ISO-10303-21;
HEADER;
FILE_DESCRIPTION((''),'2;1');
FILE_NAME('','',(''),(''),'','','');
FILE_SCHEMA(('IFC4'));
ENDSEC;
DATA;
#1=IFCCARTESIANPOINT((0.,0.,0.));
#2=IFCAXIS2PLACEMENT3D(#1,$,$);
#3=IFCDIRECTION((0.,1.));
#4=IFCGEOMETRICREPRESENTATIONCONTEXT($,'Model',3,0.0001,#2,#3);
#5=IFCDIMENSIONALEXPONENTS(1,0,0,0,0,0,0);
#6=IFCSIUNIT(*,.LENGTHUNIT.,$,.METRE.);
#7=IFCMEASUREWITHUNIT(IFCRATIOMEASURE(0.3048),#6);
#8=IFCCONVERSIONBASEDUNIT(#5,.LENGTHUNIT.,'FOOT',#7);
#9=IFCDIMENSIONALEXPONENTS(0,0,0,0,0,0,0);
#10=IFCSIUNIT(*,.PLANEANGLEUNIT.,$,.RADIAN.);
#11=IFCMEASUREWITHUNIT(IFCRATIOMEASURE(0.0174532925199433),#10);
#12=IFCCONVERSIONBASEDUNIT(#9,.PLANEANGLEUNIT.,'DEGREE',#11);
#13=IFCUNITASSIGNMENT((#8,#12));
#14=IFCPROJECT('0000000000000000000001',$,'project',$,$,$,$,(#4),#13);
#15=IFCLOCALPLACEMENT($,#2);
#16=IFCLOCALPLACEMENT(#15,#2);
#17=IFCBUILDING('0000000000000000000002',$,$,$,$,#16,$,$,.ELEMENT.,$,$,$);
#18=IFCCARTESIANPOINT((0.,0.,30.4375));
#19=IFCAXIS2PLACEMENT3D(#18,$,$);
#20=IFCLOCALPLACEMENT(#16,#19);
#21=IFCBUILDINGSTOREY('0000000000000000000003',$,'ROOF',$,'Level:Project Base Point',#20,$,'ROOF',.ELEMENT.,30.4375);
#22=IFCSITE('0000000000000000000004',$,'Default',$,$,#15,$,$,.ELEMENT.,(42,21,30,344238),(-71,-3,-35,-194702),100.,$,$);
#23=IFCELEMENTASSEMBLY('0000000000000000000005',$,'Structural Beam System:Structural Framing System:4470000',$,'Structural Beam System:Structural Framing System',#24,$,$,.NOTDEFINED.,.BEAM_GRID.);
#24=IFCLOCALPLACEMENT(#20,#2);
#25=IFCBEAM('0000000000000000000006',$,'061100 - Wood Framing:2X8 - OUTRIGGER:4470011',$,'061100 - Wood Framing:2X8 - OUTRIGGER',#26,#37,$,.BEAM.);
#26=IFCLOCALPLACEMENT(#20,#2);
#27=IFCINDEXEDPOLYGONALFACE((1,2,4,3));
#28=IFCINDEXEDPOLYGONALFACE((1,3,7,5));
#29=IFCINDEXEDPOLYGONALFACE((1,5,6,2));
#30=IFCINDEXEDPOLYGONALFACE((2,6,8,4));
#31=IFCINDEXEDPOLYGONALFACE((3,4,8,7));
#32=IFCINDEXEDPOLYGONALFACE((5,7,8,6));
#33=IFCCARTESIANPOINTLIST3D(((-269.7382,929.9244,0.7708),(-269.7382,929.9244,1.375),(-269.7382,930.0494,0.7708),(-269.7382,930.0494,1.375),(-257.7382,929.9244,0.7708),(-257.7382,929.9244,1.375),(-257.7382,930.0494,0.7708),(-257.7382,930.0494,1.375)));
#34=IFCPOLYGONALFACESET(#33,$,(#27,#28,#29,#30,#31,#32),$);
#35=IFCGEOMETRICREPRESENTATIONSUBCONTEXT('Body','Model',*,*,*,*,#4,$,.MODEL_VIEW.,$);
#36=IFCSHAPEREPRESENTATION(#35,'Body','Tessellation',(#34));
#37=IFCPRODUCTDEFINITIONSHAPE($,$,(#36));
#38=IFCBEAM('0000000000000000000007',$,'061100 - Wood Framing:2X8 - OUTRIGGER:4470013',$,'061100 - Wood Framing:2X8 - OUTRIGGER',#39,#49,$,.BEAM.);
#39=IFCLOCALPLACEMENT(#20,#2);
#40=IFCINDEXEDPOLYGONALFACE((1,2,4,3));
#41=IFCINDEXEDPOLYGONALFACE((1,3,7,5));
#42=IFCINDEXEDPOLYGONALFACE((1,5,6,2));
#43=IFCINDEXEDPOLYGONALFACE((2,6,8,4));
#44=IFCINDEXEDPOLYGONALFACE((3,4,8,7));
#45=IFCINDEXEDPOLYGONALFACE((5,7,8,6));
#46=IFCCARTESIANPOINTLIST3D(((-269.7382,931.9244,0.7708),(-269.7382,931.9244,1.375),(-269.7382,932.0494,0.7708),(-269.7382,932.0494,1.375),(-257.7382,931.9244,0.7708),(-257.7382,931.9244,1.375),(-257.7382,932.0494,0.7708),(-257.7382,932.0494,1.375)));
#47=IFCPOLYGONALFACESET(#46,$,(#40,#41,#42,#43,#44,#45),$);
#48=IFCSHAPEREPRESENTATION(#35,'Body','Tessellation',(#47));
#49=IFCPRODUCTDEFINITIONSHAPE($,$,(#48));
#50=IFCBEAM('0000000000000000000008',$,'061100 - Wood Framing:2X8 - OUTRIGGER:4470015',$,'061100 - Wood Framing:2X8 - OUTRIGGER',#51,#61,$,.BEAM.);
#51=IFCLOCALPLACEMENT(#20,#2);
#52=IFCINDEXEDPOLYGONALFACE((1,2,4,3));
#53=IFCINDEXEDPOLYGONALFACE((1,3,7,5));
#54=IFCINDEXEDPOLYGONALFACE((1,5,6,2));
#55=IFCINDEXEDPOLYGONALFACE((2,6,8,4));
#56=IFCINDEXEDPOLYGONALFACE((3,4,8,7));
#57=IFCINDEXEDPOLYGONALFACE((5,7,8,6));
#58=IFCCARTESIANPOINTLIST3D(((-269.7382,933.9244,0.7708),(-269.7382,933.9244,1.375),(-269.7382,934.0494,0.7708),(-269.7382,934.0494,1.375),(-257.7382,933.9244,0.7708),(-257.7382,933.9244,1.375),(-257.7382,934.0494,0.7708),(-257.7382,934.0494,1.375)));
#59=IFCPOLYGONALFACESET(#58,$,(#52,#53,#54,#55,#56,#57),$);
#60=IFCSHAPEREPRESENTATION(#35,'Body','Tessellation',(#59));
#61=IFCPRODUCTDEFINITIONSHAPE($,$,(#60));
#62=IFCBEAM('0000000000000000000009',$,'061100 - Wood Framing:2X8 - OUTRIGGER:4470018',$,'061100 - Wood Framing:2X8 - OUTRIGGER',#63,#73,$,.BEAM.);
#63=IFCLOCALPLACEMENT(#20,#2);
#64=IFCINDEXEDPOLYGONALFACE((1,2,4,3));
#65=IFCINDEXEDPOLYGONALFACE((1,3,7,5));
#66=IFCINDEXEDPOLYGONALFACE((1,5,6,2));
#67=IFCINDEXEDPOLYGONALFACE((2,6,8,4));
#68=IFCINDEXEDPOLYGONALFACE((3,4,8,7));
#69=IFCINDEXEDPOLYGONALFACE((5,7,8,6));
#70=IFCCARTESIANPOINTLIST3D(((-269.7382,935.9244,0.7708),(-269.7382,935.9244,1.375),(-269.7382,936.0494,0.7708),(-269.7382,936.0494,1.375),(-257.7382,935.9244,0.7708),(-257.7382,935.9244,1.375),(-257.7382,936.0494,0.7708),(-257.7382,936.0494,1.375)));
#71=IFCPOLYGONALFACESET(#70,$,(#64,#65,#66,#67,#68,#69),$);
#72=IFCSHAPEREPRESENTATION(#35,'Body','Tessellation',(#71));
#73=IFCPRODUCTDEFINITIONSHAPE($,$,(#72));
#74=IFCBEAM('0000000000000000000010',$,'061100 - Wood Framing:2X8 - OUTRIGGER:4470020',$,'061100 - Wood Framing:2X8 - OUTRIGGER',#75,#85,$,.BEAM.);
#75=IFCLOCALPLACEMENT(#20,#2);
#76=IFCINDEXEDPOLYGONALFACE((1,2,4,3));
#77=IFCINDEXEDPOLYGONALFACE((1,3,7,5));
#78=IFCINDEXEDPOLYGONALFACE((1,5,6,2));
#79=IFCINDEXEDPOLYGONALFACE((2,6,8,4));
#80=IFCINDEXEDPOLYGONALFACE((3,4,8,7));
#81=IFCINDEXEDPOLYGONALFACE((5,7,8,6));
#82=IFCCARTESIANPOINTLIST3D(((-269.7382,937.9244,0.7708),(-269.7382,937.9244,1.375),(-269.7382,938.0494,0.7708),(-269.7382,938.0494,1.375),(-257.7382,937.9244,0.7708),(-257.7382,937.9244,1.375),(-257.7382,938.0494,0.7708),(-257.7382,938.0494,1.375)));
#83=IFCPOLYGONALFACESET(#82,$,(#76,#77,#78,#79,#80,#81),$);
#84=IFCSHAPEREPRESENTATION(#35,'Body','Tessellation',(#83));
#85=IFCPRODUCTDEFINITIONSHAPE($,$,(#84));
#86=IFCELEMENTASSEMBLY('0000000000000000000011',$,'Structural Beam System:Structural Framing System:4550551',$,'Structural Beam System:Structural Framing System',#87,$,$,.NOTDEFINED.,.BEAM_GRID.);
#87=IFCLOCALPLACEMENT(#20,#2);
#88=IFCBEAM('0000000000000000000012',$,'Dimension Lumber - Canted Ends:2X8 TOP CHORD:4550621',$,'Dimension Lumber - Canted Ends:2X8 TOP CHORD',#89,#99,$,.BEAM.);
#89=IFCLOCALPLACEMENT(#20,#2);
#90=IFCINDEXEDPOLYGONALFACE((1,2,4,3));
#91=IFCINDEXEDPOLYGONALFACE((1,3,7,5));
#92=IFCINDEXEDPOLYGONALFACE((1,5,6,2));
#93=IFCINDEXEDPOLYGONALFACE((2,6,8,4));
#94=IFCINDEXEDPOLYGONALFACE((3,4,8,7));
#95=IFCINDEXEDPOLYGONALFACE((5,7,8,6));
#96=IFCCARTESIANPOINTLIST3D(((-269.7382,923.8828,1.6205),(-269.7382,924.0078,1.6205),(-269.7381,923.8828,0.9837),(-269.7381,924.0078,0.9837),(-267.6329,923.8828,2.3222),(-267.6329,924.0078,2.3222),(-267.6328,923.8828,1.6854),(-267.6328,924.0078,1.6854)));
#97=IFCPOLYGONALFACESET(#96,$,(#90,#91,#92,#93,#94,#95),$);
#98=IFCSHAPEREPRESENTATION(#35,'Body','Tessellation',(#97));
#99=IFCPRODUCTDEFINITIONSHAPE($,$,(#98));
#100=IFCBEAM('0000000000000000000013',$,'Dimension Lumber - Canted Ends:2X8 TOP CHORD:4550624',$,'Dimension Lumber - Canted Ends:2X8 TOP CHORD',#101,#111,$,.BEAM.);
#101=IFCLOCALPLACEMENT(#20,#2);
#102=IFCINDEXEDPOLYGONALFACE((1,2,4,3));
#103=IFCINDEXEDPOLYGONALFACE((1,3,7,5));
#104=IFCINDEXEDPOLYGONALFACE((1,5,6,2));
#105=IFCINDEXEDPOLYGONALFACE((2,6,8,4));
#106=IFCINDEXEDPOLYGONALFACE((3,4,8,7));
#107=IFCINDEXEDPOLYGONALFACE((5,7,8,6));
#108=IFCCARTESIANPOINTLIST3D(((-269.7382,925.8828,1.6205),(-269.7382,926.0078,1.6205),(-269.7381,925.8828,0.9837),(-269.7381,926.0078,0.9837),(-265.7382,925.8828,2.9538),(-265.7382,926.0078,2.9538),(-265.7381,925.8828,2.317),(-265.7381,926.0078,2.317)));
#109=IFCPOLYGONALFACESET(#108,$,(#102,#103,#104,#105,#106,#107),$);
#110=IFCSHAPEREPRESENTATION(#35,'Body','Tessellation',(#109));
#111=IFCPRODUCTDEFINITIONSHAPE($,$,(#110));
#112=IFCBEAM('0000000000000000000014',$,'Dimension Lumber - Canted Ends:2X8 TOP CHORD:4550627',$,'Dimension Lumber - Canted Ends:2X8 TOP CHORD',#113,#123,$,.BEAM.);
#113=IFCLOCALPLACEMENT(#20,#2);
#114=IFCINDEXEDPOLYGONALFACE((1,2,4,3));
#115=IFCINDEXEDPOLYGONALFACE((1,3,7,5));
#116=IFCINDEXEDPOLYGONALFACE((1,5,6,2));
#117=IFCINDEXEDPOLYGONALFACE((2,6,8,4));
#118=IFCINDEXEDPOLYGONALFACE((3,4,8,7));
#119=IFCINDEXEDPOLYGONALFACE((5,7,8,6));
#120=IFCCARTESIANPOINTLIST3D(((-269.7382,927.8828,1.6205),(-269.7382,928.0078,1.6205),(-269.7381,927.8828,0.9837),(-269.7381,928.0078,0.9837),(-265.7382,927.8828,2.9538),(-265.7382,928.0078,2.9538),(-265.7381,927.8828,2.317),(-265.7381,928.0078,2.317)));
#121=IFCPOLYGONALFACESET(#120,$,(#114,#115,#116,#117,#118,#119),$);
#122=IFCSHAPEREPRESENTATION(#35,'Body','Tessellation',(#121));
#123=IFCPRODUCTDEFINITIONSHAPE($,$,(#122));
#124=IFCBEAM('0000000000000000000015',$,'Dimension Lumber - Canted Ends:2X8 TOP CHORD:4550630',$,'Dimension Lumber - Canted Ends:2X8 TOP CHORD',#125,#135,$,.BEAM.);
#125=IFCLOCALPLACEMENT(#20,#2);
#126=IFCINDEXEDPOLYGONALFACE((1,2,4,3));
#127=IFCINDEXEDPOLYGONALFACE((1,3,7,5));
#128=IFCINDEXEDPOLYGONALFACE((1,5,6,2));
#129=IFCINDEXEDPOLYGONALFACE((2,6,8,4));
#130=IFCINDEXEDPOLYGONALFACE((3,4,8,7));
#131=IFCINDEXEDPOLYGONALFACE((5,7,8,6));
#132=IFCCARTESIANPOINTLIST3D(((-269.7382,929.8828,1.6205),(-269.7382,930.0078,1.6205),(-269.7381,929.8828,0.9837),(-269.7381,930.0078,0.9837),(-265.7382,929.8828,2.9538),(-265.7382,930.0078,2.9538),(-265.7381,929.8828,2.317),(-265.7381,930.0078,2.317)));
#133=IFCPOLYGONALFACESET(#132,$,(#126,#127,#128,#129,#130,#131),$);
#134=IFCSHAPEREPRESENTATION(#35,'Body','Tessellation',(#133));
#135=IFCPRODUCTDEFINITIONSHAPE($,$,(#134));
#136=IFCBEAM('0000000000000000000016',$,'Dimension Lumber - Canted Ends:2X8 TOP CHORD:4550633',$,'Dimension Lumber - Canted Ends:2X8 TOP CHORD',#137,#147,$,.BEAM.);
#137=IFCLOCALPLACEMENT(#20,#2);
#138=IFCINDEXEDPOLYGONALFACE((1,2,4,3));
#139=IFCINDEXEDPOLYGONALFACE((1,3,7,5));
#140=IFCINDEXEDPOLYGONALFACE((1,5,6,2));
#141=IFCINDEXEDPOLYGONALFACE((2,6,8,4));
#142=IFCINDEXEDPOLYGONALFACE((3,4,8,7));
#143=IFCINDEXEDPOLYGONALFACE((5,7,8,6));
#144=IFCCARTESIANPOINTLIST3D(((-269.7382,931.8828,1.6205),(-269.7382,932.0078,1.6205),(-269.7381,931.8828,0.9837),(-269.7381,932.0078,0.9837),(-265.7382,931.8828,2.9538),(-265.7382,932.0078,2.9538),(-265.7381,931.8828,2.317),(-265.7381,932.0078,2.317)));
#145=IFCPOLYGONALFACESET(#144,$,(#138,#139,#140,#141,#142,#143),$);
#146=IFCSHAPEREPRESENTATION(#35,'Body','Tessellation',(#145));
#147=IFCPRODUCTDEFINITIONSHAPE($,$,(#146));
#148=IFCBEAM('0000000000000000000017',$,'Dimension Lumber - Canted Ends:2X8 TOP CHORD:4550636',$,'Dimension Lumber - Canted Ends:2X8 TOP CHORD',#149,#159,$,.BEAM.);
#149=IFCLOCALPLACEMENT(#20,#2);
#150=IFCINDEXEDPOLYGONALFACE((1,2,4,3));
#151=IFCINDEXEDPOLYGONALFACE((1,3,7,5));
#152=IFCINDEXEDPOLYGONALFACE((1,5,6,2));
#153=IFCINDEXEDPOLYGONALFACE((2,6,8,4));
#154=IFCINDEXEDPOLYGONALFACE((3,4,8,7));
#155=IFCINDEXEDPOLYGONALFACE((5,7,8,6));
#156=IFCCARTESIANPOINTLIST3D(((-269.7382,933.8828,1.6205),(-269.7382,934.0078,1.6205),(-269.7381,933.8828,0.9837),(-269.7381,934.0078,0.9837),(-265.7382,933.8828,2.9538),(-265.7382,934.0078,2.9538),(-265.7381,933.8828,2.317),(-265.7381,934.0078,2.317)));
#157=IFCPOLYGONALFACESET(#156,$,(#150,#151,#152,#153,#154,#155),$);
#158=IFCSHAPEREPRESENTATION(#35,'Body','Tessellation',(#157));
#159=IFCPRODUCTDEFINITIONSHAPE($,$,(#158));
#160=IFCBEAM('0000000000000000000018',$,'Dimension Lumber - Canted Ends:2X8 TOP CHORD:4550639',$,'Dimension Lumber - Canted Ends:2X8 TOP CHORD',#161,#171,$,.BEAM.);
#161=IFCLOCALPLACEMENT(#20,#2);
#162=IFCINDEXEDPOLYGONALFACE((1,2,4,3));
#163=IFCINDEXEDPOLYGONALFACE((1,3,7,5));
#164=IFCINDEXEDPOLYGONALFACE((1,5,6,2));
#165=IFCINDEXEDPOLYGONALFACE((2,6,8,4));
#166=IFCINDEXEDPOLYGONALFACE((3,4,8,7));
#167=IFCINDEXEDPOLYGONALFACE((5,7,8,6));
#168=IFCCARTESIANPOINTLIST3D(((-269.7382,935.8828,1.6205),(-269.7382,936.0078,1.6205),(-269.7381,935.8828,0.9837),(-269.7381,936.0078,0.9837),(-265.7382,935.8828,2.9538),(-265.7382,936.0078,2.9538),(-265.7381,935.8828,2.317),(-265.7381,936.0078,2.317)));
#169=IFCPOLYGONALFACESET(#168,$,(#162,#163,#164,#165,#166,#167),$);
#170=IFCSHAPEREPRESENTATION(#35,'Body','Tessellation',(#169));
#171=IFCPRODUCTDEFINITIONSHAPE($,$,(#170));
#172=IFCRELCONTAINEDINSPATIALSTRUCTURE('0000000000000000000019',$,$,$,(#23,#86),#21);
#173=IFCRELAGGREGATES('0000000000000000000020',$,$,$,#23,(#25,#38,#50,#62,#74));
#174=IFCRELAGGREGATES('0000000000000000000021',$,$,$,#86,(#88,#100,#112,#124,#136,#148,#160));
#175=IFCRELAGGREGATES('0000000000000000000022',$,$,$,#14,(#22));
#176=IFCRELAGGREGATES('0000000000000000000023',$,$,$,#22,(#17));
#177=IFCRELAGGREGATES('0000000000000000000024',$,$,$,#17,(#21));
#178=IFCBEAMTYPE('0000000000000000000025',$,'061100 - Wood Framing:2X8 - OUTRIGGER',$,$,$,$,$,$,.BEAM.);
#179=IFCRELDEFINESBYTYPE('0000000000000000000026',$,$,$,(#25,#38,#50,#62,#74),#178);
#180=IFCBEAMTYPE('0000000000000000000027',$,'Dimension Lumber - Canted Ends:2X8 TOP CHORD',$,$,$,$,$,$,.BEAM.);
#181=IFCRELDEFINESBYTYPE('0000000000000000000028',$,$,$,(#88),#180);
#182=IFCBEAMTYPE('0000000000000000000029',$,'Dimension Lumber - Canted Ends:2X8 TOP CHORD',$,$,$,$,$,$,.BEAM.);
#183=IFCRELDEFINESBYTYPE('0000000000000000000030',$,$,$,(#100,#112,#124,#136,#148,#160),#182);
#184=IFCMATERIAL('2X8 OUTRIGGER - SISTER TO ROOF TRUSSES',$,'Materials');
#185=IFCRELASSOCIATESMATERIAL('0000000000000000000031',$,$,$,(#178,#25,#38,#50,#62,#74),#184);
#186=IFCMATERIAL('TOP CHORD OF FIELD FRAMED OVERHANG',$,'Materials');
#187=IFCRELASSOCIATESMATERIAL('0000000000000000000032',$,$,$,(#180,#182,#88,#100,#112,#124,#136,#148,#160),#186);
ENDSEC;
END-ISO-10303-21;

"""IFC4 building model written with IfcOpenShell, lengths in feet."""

from ifc_helpers import new_model, entity, si_unit, converted_unit, direction, frame, frame_2d, origin, origin_2d_with_axis, place, context, subcontext, project, spatial, rectangle, extrude, clip, halfspace, source, transform, mapped, material, material_profile, profile_set, profile_usage, type_object, type_shapes, element, aggregate, save


model = new_model("IFC4")

# Units and contexts
model_context = context("Model", 3, precision=0.0001, world=origin(), true_north=direction((0.0, 1.0)))
body_context = subcontext(model_context, "Body", "Model", "MODEL_VIEW")
ifc_project = project(units=[converted_unit("LENGTHUNIT", "FOOT", entity("IfcRatioMeasure", 0.3048), si_unit("LENGTHUNIT", "METRE"), dimensions=[1, 0, 0, 0, 0, 0, 0]), converted_unit("PLANEANGLEUNIT", "DEGREE", entity("IfcRatioMeasure", 0.0174532925199433), si_unit("PLANEANGLEUNIT", "RADIAN"), dimensions=[0, 0, 0, 0, 0, 0, 0])], contexts=[model_context])

# Site, building, storey
site_placement = place(None, origin())
site = spatial("IfcSite", under=ifc_project, at=site_placement, Name="Default", CompositionType="ELEMENT", RefLatitude=(42, 21, 30, 344238), RefLongitude=(-71, -3, -35, -194702), RefElevation=100.0)
building_placement = place(site_placement, origin())
building = spatial("IfcBuilding", under=site, at=building_placement, CompositionType="ELEMENT")
storey_placement = place(building_placement, frame((0.0, 0.0, 30.4375)))
storey = spatial("IfcBuildingStorey", under=building, at=storey_placement, Name="ROOF", ObjectType="Level:Project Base Point", LongName="ROOF", CompositionType="ELEMENT", Elevation=30.4375)

# Element assemblies, beams
ifc_material_1 = material(Name="TOP CHORD OF FIELD FRAMED OVERHANG", Category="Materials")
ifc_material_profile_1 = material_profile(ifc_material_1, rectangle(XDim=0.6042, YDim=0.125, at=origin_2d_with_axis()), Name="2X8 TOP CHORD")
ifc_profile_set_1 = profile_set([ifc_material_profile_1], Name="2X8 TOP CHORD")
assembly_1_placement = place(storey_placement, origin())
assembly_1 = element("IfcElementAssembly", 1, at=assembly_1_placement, inside=storey, Name="Structural Beam System:Structural Framing System:4470000", ObjectType="Structural Beam System:Structural Framing System", AssemblyPlace="NOTDEFINED", PredefinedType="BEAM_GRID")
ifc_material_2 = material(Name="2X8 OUTRIGGER - SISTER TO ROOF TRUSSES", Category="Materials")
ifc_material_profile_2 = material_profile(ifc_material_2, rectangle(XDim=0.6042, YDim=0.125, at=origin_2d_with_axis()), Name="2X8 - OUTRIGGER")
ifc_profile_set_2 = profile_set([ifc_material_profile_2], Name="2X8 - OUTRIGGER")
beam_type_1 = type_object("IfcBeamType", Name="061100 - Wood Framing:2X8 - OUTRIGGER", PredefinedType="BEAM", material=ifc_profile_set_2)
shared_shape_1 = source(origin(), body_context, "Body", "SweptSolid", [
    extrude(rectangle(XDim=0.6042, YDim=0.125, at=origin_2d_with_axis()), frame((-6.0, 0.0, 0.0), z_axis=(1.0, 0.0, 0.0), x_axis=(0.0, 0.0, -1.0)), (0.0, 0.0, 1.0), 12.0),
])
type_shapes(beam_type_1, [shared_shape_1])
ifc_profile_usage_1 = profile_usage(ifc_profile_set_2, cardinal=8)
beam_1_placement = place(assembly_1_placement, frame((-263.7382, 929.9869, 1.0729), z_axis=(0.0, 0.0, 1.0), x_axis=(-1.0, 0.0, 0.0)))
beam_1 = element("IfcBeam", 2, at=beam_1_placement, type_object=beam_type_1, material=ifc_profile_usage_1, Name="061100 - Wood Framing:2X8 - OUTRIGGER:4470011", ObjectType="061100 - Wood Framing:2X8 - OUTRIGGER", PredefinedType="BEAM", context=body_context, shape_type="MappedRepresentation", body=[
    mapped(shared_shape_1, transform((0.0, 0.0, 0.0), scale=1.0)),
])
ifc_profile_usage_2 = profile_usage(ifc_profile_set_2, cardinal=8)
beam_2_placement = place(assembly_1_placement, frame((-263.7382, 931.9869, 1.0729), z_axis=(0.0, 0.0, 1.0), x_axis=(-1.0, 0.0, 0.0)))
beam_2 = element("IfcBeam", 3, at=beam_2_placement, type_object=beam_type_1, material=ifc_profile_usage_2, Name="061100 - Wood Framing:2X8 - OUTRIGGER:4470013", ObjectType="061100 - Wood Framing:2X8 - OUTRIGGER", PredefinedType="BEAM", context=body_context, shape_type="MappedRepresentation", body=[
    mapped(shared_shape_1, transform((0.0, 0.0, 0.0), scale=1.0)),
])
ifc_profile_usage_3 = profile_usage(ifc_profile_set_2, cardinal=8)
beam_3_placement = place(assembly_1_placement, frame((-263.7382, 933.9869, 1.0729), z_axis=(0.0, 0.0, 1.0), x_axis=(-1.0, 0.0, 0.0)))
beam_3 = element("IfcBeam", 4, at=beam_3_placement, type_object=beam_type_1, material=ifc_profile_usage_3, Name="061100 - Wood Framing:2X8 - OUTRIGGER:4470015", ObjectType="061100 - Wood Framing:2X8 - OUTRIGGER", PredefinedType="BEAM", context=body_context, shape_type="MappedRepresentation", body=[
    mapped(shared_shape_1, transform((0.0, 0.0, 0.0), scale=1.0)),
])
ifc_profile_usage_4 = profile_usage(ifc_profile_set_2, cardinal=8)
beam_4_placement = place(assembly_1_placement, frame((-263.7382, 935.9869, 1.0729), z_axis=(0.0, 0.0, 1.0), x_axis=(-1.0, 0.0, 0.0)))
beam_4 = element("IfcBeam", 5, at=beam_4_placement, type_object=beam_type_1, material=ifc_profile_usage_4, Name="061100 - Wood Framing:2X8 - OUTRIGGER:4470018", ObjectType="061100 - Wood Framing:2X8 - OUTRIGGER", PredefinedType="BEAM", context=body_context, shape_type="MappedRepresentation", body=[
    mapped(shared_shape_1, transform((0.0, 0.0, 0.0), scale=1.0)),
])
ifc_profile_usage_5 = profile_usage(ifc_profile_set_2, cardinal=8)
beam_5_placement = place(assembly_1_placement, frame((-263.7382, 937.9869, 1.0729), z_axis=(0.0, 0.0, 1.0), x_axis=(-1.0, 0.0, 0.0)))
beam_5 = element("IfcBeam", 6, at=beam_5_placement, type_object=beam_type_1, material=ifc_profile_usage_5, Name="061100 - Wood Framing:2X8 - OUTRIGGER:4470020", ObjectType="061100 - Wood Framing:2X8 - OUTRIGGER", PredefinedType="BEAM", context=body_context, shape_type="MappedRepresentation", body=[
    mapped(shared_shape_1, transform((0.0, 0.0, 0.0), scale=1.0)),
])
aggregate(assembly_1, [beam_1, beam_2, beam_3, beam_4, beam_5])
assembly_2_placement = place(storey_placement, origin())
assembly_2 = element("IfcElementAssembly", 7, at=assembly_2_placement, inside=storey, Name="Structural Beam System:Structural Framing System:4550551", ObjectType="Structural Beam System:Structural Framing System", AssemblyPlace="NOTDEFINED", PredefinedType="BEAM_GRID")
ifc_profile_usage_6 = profile_usage(ifc_profile_set_1, cardinal=8)
beam_type_2 = type_object("IfcBeamType", Name="Dimension Lumber - Canted Ends:2X8 TOP CHORD", PredefinedType="BEAM", material=ifc_profile_set_1)
shared_shape_2 = source(origin(), body_context, "Body", "Clipping", [
    clip(clip(extrude(rectangle(XDim=0.6042, YDim=0.125, at=frame_2d((0.0, 0.0), x_axis=(1.0, 0.0))), frame((-1.1096, 0.0, 0.0), z_axis=(1.0, 0.0, 0.0), x_axis=(0.0, 0.0, -1.0)), (0.0, 0.0, 1.0), 2.4205), halfspace(frame((1.1096, -0.0625, -0.3021), z_axis=(0.948711, 0.0, -0.316146), x_axis=(0.0, 1.0, 0.0)), False)), halfspace(frame((-0.9083, -0.0625, 0.3021), z_axis=(-0.948711, 0.0, 0.316146), x_axis=(0.0, 1.0, 0.0)), False)),
])
type_shapes(beam_type_2, [shared_shape_2])
beam_6_placement = place(assembly_2_placement, frame((-268.781, 923.9453, 1.6211), z_axis=(-0.316228, 0.0, 0.948683), x_axis=(0.948683, 0.0, 0.316228)))
beam_6 = element("IfcBeam", 8, at=beam_6_placement, type_object=beam_type_2, material=ifc_profile_usage_6, Name="Dimension Lumber - Canted Ends:2X8 TOP CHORD:4550621", ObjectType="Dimension Lumber - Canted Ends:2X8 TOP CHORD", PredefinedType="BEAM", context=body_context, shape_type="MappedRepresentation", body=[
    mapped(shared_shape_2, transform((0.0, 0.0, 0.0), scale=1.0)),
])
ifc_profile_usage_7 = profile_usage(ifc_profile_set_1, cardinal=8)
beam_type_3 = type_object("IfcBeamType", Name="Dimension Lumber - Canted Ends:2X8 TOP CHORD", PredefinedType="BEAM", material=ifc_profile_set_1)
shared_shape_3 = source(origin(), body_context, "Body", "Clipping", [
    clip(clip(extrude(rectangle(XDim=0.6042, YDim=0.125, at=frame_2d((0.0, 0.0), x_axis=(1.0, 0.0))), frame((-2.1082, 0.0, 0.0), z_axis=(1.0, 0.0, 0.0), x_axis=(0.0, 0.0, -1.0)), (0.0, 0.0, 1.0), 4.4177), halfspace(frame((2.1082, -0.0625, -0.3021), z_axis=(0.948711, 0.0, -0.316146), x_axis=(0.0, 1.0, 0.0)), False)), halfspace(frame((-1.9069, -0.0625, 0.3021), z_axis=(-0.948711, 0.0, 0.316146), x_axis=(0.0, 1.0, 0.0)), False)),
])
type_shapes(beam_type_3, [shared_shape_3])
beam_7_placement = place(assembly_2_placement, frame((-267.8337, 925.9453, 1.9369), z_axis=(-0.316228, 0.0, 0.948683), x_axis=(0.948683, 0.0, 0.316228)))
beam_7 = element("IfcBeam", 9, at=beam_7_placement, type_object=beam_type_3, material=ifc_profile_usage_7, Name="Dimension Lumber - Canted Ends:2X8 TOP CHORD:4550624", ObjectType="Dimension Lumber - Canted Ends:2X8 TOP CHORD", PredefinedType="BEAM", context=body_context, shape_type="MappedRepresentation", body=[
    mapped(shared_shape_3, transform((0.0, 0.0, 0.0), scale=1.0)),
])
ifc_profile_usage_8 = profile_usage(ifc_profile_set_1, cardinal=8)
beam_8_placement = place(assembly_2_placement, frame((-267.8337, 927.9453, 1.9369), z_axis=(-0.316228, 0.0, 0.948683), x_axis=(0.948683, 0.0, 0.316228)))
beam_8 = element("IfcBeam", 10, at=beam_8_placement, type_object=beam_type_3, material=ifc_profile_usage_8, Name="Dimension Lumber - Canted Ends:2X8 TOP CHORD:4550627", ObjectType="Dimension Lumber - Canted Ends:2X8 TOP CHORD", PredefinedType="BEAM", context=body_context, shape_type="MappedRepresentation", body=[
    mapped(shared_shape_3, transform((0.0, 0.0, 0.0), scale=1.0)),
])
ifc_profile_usage_9 = profile_usage(ifc_profile_set_1, cardinal=8)
beam_9_placement = place(assembly_2_placement, frame((-267.8337, 929.9453, 1.9369), z_axis=(-0.316228, 0.0, 0.948683), x_axis=(0.948683, 0.0, 0.316228)))
beam_9 = element("IfcBeam", 11, at=beam_9_placement, type_object=beam_type_3, material=ifc_profile_usage_9, Name="Dimension Lumber - Canted Ends:2X8 TOP CHORD:4550630", ObjectType="Dimension Lumber - Canted Ends:2X8 TOP CHORD", PredefinedType="BEAM", context=body_context, shape_type="MappedRepresentation", body=[
    mapped(shared_shape_3, transform((0.0, 0.0, 0.0), scale=1.0)),
])
ifc_profile_usage_10 = profile_usage(ifc_profile_set_1, cardinal=8)
beam_10_placement = place(assembly_2_placement, frame((-267.8337, 931.9453, 1.9369), z_axis=(-0.316228, 0.0, 0.948683), x_axis=(0.948683, 0.0, 0.316228)))
beam_10 = element("IfcBeam", 12, at=beam_10_placement, type_object=beam_type_3, material=ifc_profile_usage_10, Name="Dimension Lumber - Canted Ends:2X8 TOP CHORD:4550633", ObjectType="Dimension Lumber - Canted Ends:2X8 TOP CHORD", PredefinedType="BEAM", context=body_context, shape_type="MappedRepresentation", body=[
    mapped(shared_shape_3, transform((0.0, 0.0, 0.0), scale=1.0)),
])
ifc_profile_usage_11 = profile_usage(ifc_profile_set_1, cardinal=8)
beam_11_placement = place(assembly_2_placement, frame((-267.8337, 933.9453, 1.9369), z_axis=(-0.316228, 0.0, 0.948683), x_axis=(0.948683, 0.0, 0.316228)))
beam_11 = element("IfcBeam", 13, at=beam_11_placement, type_object=beam_type_3, material=ifc_profile_usage_11, Name="Dimension Lumber - Canted Ends:2X8 TOP CHORD:4550636", ObjectType="Dimension Lumber - Canted Ends:2X8 TOP CHORD", PredefinedType="BEAM", context=body_context, shape_type="MappedRepresentation", body=[
    mapped(shared_shape_3, transform((0.0, 0.0, 0.0), scale=1.0)),
])
ifc_profile_usage_12 = profile_usage(ifc_profile_set_1, cardinal=8)
beam_12_placement = place(assembly_2_placement, frame((-267.8337, 935.9453, 1.9369), z_axis=(-0.316228, 0.0, 0.948683), x_axis=(0.948683, 0.0, 0.316228)))
beam_12 = element("IfcBeam", 14, at=beam_12_placement, type_object=beam_type_3, material=ifc_profile_usage_12, Name="Dimension Lumber - Canted Ends:2X8 TOP CHORD:4550639", ObjectType="Dimension Lumber - Canted Ends:2X8 TOP CHORD", PredefinedType="BEAM", context=body_context, shape_type="MappedRepresentation", body=[
    mapped(shared_shape_3, transform((0.0, 0.0, 0.0), scale=1.0)),
])
aggregate(assembly_2, [beam_6, beam_7, beam_8, beam_9, beam_10, beam_11, beam_12])

save(model, "model.ifc")
